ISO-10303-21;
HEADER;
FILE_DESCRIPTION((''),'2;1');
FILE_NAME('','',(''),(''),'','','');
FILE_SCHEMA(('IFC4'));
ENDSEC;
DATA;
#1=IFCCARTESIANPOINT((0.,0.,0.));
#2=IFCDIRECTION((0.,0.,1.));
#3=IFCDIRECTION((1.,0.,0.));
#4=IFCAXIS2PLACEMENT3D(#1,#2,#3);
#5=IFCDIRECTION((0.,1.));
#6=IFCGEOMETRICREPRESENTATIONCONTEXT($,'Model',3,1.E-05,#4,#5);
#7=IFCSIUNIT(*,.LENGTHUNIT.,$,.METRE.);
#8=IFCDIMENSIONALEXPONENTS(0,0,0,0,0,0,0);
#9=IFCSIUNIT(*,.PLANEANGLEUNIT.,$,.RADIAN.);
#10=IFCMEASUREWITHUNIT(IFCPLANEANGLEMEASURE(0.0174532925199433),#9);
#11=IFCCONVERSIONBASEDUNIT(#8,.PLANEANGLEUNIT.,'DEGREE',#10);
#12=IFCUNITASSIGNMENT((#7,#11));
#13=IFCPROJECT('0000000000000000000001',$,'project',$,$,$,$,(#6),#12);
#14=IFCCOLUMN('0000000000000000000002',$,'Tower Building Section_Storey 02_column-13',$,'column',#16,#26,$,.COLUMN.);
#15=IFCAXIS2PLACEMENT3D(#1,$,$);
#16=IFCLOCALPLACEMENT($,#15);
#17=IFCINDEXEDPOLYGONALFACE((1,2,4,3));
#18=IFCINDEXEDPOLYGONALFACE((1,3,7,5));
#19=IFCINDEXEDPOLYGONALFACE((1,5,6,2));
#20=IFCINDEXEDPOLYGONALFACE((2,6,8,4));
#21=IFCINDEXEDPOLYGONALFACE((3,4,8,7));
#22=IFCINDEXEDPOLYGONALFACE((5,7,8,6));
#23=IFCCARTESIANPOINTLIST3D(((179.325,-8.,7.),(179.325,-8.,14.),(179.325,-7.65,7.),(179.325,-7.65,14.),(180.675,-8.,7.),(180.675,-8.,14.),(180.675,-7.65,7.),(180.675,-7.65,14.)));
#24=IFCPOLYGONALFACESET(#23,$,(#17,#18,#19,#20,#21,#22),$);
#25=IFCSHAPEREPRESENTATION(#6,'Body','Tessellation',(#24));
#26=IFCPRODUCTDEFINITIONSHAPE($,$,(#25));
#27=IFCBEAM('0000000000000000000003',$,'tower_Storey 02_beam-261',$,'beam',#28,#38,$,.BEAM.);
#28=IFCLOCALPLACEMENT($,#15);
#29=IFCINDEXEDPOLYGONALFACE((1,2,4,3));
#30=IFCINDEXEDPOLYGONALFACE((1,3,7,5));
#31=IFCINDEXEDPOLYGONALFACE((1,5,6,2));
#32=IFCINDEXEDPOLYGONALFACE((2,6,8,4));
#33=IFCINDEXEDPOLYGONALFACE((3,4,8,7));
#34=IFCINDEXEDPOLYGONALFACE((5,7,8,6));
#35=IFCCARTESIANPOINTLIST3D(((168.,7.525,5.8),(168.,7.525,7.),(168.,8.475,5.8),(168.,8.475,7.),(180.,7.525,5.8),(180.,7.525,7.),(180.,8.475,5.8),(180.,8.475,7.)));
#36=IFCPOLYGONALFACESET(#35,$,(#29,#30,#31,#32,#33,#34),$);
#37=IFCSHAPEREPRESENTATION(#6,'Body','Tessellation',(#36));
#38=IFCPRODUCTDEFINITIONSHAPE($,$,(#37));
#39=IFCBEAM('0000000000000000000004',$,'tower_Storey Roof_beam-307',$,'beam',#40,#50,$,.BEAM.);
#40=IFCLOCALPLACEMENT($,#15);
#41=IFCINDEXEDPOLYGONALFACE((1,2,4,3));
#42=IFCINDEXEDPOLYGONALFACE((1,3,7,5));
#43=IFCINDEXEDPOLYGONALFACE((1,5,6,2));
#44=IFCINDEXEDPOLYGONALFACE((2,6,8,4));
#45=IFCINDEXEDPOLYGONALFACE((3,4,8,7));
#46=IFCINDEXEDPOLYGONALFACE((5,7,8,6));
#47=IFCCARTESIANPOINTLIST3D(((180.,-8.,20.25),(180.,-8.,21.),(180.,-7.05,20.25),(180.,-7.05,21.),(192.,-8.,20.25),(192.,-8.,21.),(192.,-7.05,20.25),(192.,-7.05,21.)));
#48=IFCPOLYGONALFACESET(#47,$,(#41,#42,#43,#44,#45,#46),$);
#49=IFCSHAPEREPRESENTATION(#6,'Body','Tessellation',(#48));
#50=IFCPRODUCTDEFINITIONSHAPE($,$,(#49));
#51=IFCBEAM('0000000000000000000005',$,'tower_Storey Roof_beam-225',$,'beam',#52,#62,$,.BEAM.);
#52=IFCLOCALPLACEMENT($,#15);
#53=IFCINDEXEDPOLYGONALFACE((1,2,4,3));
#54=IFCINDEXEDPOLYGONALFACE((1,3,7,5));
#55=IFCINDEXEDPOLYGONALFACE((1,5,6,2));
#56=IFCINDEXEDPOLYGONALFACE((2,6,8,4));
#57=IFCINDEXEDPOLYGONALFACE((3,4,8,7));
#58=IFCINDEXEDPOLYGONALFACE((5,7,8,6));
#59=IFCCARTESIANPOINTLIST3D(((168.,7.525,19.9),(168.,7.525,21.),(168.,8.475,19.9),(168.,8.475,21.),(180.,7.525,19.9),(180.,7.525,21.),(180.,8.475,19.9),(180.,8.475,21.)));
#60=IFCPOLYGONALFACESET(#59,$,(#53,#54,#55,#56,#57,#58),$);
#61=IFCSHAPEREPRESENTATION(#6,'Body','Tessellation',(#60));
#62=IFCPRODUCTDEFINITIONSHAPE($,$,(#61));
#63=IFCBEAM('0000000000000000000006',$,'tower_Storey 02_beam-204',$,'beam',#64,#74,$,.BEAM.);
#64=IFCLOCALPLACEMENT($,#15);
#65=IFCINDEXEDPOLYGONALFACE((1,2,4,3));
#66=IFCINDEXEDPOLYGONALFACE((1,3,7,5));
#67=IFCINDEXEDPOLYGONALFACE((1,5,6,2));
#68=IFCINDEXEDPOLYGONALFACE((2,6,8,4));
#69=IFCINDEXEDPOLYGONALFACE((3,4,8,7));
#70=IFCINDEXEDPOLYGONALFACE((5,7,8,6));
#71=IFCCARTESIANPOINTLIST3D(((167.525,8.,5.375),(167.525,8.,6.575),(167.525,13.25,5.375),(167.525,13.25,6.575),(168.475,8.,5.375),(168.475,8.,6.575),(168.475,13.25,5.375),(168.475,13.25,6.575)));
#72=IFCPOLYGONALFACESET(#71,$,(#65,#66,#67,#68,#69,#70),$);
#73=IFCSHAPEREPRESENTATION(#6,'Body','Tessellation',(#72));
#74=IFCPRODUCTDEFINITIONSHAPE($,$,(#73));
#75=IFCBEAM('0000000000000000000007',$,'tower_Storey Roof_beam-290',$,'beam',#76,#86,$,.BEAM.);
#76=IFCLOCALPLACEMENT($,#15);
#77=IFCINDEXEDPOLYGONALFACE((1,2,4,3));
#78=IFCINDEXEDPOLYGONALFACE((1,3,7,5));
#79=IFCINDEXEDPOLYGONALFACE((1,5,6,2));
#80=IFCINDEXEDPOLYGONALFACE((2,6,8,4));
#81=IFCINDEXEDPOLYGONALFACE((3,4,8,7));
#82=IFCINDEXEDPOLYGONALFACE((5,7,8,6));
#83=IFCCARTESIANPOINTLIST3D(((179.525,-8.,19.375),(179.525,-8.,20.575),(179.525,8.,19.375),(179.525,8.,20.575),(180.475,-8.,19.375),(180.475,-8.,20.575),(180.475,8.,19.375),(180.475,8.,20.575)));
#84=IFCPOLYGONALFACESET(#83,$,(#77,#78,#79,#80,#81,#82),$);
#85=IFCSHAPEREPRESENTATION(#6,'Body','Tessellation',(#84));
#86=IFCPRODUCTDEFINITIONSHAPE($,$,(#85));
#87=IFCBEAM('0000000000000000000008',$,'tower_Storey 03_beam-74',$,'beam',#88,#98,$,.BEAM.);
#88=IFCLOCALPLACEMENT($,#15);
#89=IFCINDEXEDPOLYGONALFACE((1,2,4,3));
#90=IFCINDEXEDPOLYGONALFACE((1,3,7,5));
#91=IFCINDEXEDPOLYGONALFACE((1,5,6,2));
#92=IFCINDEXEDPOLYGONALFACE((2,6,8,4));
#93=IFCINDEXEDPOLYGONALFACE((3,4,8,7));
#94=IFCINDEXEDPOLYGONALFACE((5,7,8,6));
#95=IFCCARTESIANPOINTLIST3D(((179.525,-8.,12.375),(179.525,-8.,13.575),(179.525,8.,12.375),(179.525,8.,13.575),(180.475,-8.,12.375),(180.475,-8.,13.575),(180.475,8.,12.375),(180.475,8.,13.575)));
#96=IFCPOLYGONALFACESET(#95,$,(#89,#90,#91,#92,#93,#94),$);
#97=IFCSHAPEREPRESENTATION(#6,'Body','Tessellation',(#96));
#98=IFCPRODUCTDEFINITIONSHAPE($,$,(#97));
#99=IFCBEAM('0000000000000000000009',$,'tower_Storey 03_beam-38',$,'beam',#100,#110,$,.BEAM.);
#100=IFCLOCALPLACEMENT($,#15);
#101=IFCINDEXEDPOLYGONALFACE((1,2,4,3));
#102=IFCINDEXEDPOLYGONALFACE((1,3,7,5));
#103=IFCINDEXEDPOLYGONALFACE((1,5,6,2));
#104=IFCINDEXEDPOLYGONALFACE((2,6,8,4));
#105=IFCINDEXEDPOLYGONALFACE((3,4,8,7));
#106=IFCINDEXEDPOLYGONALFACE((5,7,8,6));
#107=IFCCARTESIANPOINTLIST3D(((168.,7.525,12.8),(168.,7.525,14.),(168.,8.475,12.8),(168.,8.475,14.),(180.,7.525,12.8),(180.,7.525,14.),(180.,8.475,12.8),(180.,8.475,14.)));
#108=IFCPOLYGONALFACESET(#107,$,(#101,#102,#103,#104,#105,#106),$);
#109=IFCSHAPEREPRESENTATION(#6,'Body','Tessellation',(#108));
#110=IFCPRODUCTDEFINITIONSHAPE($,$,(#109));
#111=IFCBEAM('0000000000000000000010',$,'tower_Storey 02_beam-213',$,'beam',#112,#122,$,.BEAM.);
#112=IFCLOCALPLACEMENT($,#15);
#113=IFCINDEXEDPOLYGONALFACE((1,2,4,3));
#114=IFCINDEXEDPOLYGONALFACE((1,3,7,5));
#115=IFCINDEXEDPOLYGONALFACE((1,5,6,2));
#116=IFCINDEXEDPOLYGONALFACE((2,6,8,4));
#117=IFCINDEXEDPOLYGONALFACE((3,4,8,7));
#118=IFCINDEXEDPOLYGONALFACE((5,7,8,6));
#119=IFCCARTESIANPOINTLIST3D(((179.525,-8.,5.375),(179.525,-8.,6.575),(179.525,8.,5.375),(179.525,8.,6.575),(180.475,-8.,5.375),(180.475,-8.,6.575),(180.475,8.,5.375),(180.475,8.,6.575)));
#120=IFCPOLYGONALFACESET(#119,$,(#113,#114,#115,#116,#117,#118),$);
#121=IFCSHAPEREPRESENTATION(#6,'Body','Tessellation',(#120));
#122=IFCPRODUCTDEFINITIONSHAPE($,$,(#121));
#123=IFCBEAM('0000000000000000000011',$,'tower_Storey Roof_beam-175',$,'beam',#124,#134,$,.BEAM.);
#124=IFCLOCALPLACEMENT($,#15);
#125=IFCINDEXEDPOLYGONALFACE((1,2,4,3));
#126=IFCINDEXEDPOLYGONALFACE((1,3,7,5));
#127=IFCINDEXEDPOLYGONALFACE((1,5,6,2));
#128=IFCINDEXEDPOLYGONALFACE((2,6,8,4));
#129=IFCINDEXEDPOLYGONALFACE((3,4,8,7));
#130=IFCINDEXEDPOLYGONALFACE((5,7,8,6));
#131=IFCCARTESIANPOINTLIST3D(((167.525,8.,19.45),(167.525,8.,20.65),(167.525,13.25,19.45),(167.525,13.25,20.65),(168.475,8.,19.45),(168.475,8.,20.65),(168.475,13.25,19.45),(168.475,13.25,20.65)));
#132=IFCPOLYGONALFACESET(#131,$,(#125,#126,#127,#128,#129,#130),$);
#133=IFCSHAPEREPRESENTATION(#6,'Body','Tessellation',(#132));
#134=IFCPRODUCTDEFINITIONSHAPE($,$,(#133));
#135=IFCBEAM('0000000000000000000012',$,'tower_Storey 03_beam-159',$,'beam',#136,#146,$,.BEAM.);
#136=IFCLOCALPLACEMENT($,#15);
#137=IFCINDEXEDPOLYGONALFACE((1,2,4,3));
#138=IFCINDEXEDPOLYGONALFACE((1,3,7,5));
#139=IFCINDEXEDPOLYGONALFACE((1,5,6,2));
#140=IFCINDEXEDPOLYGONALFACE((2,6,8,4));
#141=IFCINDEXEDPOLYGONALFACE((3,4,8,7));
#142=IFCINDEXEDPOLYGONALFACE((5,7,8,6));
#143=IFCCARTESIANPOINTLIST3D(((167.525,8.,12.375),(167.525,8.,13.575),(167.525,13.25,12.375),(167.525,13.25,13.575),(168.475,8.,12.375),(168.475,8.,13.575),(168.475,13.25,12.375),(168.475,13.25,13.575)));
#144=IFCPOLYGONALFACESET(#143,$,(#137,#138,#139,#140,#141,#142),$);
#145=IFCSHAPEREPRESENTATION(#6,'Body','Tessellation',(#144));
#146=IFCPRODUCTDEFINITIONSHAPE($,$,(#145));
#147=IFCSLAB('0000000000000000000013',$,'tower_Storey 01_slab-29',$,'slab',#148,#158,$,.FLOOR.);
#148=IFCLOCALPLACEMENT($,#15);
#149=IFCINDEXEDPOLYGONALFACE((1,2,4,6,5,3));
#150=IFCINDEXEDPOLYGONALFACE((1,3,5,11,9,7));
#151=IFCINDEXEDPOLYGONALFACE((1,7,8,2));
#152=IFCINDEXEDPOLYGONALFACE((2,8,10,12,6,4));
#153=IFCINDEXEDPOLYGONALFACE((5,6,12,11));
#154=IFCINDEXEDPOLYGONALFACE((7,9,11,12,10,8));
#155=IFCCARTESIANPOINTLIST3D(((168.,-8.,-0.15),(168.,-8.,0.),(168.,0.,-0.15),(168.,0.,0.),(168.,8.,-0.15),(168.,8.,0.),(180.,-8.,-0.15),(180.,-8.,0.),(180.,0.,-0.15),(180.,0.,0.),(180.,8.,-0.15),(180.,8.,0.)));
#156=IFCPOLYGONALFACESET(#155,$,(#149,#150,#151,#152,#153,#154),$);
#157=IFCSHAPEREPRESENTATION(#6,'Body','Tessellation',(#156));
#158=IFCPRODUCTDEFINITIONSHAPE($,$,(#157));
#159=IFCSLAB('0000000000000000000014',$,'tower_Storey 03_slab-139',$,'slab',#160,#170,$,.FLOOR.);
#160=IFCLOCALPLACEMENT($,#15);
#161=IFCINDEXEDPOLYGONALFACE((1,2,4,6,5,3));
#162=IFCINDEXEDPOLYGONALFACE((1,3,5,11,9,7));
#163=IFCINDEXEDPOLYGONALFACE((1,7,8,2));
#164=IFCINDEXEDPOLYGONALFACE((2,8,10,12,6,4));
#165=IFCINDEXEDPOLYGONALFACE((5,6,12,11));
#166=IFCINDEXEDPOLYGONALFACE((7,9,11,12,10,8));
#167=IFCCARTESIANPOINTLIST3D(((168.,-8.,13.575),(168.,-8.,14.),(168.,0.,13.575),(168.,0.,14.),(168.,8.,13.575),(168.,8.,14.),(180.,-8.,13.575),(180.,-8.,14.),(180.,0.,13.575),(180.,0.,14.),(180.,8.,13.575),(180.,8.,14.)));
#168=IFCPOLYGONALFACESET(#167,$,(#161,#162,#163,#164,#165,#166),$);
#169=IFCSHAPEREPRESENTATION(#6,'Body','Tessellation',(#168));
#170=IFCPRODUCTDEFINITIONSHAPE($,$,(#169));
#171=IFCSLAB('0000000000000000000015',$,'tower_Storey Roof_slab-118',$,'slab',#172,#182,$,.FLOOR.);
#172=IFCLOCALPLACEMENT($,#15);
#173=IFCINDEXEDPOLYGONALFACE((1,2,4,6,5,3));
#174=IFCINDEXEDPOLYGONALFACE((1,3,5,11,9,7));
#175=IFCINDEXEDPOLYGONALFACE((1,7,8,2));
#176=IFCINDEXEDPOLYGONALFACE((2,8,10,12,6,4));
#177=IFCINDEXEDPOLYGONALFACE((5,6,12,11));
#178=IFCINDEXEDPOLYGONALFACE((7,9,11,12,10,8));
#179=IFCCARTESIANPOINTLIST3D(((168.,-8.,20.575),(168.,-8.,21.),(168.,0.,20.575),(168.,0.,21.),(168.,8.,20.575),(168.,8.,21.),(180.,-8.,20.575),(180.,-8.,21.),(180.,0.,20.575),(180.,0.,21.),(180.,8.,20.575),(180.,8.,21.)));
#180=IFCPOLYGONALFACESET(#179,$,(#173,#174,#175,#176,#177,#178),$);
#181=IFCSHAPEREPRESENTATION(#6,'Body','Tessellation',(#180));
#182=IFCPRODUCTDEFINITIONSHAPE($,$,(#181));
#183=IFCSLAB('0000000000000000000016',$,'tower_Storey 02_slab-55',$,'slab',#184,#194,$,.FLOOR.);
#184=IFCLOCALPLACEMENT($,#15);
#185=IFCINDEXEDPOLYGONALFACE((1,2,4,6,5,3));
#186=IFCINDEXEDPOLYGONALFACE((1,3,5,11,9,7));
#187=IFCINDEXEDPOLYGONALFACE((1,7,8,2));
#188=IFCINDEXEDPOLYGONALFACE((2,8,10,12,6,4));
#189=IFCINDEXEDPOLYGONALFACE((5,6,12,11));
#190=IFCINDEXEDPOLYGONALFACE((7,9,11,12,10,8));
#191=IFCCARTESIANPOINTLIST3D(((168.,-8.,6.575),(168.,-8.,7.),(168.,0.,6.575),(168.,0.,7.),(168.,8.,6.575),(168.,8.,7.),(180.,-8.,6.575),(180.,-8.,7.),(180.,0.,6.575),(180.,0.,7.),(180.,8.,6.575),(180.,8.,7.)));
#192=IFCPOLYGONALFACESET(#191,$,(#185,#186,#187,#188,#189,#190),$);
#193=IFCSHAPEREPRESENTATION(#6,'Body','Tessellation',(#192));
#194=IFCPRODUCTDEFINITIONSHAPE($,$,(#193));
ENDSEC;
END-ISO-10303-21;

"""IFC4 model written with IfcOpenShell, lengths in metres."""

from ifc_helpers import new_model, entity, si_unit, converted_unit, direction, frame, origin_with_axes, place, context, project, polyline, outline, extrude, element, save


model = new_model("IFC4")

# Units and contexts
model_context = context("Model", 3, precision=1e-05, world=origin_with_axes(), true_north=direction((0.0, 1.0)))
ifc_project = project(units=[si_unit("LENGTHUNIT", "METRE"), converted_unit("PLANEANGLEUNIT", "DEGREE", entity("IfcPlaneAngleMeasure", 0.0174532925199433), si_unit("PLANEANGLEUNIT", "RADIAN"), dimensions=[0, 0, 0, 0, 0, 0, 0])], contexts=[model_context])

# Shared definitions
placement_1 = place(None, origin_with_axes())
placement_2 = place(placement_1, origin_with_axes())

# Column
placement_3 = place(placement_1, frame((0.0, 0.0, 14.0), z_axis=(0.0, 0.0, 1.0), x_axis=(1.0, 0.0, 0.0)))
placement_4 = place(placement_1, frame((0.0, 0.0, 7.0), z_axis=(0.0, 0.0, 1.0), x_axis=(1.0, 0.0, 0.0)))
column_1_placement = place(placement_4, frame((180.0, -7.825, 0.0), z_axis=(0.0, 0.0, 1.0), x_axis=(1.0, 0.0, 0.0)))
element("IfcColumn", 1, at=column_1_placement, Name="Tower Building Section_Storey 02_column-13", ObjectType="column", PredefinedType="COLUMN", context=model_context, body=[
    extrude(outline(polyline([(-0.675, -0.175, 0.0), (0.675, -0.175, 0.0), (0.675, 0.175, 0.0), (-0.675, 0.175, 0.0), (-0.675, -0.175, 0.0)])), origin_with_axes(), (0.0, 0.0, 1.0), 7.0),
])

# Beams
beam_1_placement = place(placement_4, frame((168.0, 8.0, -0.6), z_axis=(1.0, 0.0, 0.0), x_axis=(0.0, 1.0, 0.0)))
element("IfcBeam", 2, at=beam_1_placement, Name="tower_Storey 02_beam-261", ObjectType="beam", PredefinedType="BEAM", context=model_context, body=[
    extrude(outline(polyline([(0.475, 0.6, 0.0), (-0.475, 0.6, 0.0), (-0.475, -0.6, 0.0), (0.475, -0.6, 0.0), (0.475, 0.6, 0.0)])), origin_with_axes(), (0.0, 0.0, 1.0), 12.0),
])
placement_5 = place(placement_1, frame((0.0, 0.0, 21.0), z_axis=(0.0, 0.0, 1.0), x_axis=(1.0, 0.0, 0.0)))
beam_2_placement = place(placement_5, frame((180.0, -7.525, -0.375), z_axis=(1.0, 0.0, 0.0), x_axis=(0.0, 1.0, 0.0)))
element("IfcBeam", 3, at=beam_2_placement, Name="tower_Storey Roof_beam-307", ObjectType="beam", PredefinedType="BEAM", context=model_context, body=[
    extrude(outline(polyline([(0.475, 0.375, 0.0), (-0.475, 0.375, 0.0), (-0.475, -0.375, 0.0), (0.475, -0.375, 0.0), (0.475, 0.375, 0.0)])), origin_with_axes(), (0.0, 0.0, 1.0), 12.0),
])
beam_3_placement = place(placement_5, frame((168.0, 8.0, -0.55), z_axis=(1.0, 0.0, 0.0), x_axis=(0.0, 1.0, 0.0)))
element("IfcBeam", 4, at=beam_3_placement, Name="tower_Storey Roof_beam-225", ObjectType="beam", PredefinedType="BEAM", context=model_context, body=[
    extrude(outline(polyline([(0.475, 0.55, 0.0), (-0.475, 0.55, 0.0), (-0.475, -0.55, 0.0), (0.475, -0.55, 0.0), (0.475, 0.55, 0.0)])), origin_with_axes(), (0.0, 0.0, 1.0), 12.0),
])
beam_4_placement = place(placement_4, frame((168.0, 8.0, -1.025), z_axis=(0.0, 1.0, 0.0), x_axis=(-1.0, 0.0, 0.0)))
element("IfcBeam", 5, at=beam_4_placement, Name="tower_Storey 02_beam-204", ObjectType="beam", PredefinedType="BEAM", context=model_context, body=[
    extrude(outline(polyline([(0.475, 0.6, 0.0), (-0.475, 0.6, 0.0), (-0.475, -0.6, 0.0), (0.475, -0.6, 0.0), (0.475, 0.6, 0.0)])), origin_with_axes(), (0.0, 0.0, 1.0), 5.25),
])
beam_5_placement = place(placement_5, frame((180.0, -8.0, -1.025), z_axis=(0.0, 1.0, 0.0), x_axis=(-1.0, 0.0, 0.0)))
element("IfcBeam", 6, at=beam_5_placement, Name="tower_Storey Roof_beam-290", ObjectType="beam", PredefinedType="BEAM", context=model_context, body=[
    extrude(outline(polyline([(0.475, 0.6, 0.0), (-0.475, 0.6, 0.0), (-0.475, -0.6, 0.0), (0.475, -0.6, 0.0), (0.475, 0.6, 0.0)])), origin_with_axes(), (0.0, 0.0, 1.0), 16.0),
])
beam_6_placement = place(placement_3, frame((180.0, -8.0, -1.025), z_axis=(0.0, 1.0, 0.0), x_axis=(-1.0, 0.0, 0.0)))
element("IfcBeam", 7, at=beam_6_placement, Name="tower_Storey 03_beam-74", ObjectType="beam", PredefinedType="BEAM", context=model_context, body=[
    extrude(outline(polyline([(0.475, 0.6, 0.0), (-0.475, 0.6, 0.0), (-0.475, -0.6, 0.0), (0.475, -0.6, 0.0), (0.475, 0.6, 0.0)])), origin_with_axes(), (0.0, 0.0, 1.0), 16.0),
])
beam_7_placement = place(placement_3, frame((168.0, 8.0, -0.6), z_axis=(1.0, 0.0, 0.0), x_axis=(0.0, 1.0, 0.0)))
element("IfcBeam", 8, at=beam_7_placement, Name="tower_Storey 03_beam-38", ObjectType="beam", PredefinedType="BEAM", context=model_context, body=[
    extrude(outline(polyline([(0.475, 0.6, 0.0), (-0.475, 0.6, 0.0), (-0.475, -0.6, 0.0), (0.475, -0.6, 0.0), (0.475, 0.6, 0.0)])), origin_with_axes(), (0.0, 0.0, 1.0), 12.0),
])
beam_8_placement = place(placement_4, frame((180.0, -8.0, -1.025), z_axis=(0.0, 1.0, 0.0), x_axis=(-1.0, 0.0, 0.0)))
element("IfcBeam", 9, at=beam_8_placement, Name="tower_Storey 02_beam-213", ObjectType="beam", PredefinedType="BEAM", context=model_context, body=[
    extrude(outline(polyline([(0.475, 0.6, 0.0), (-0.475, 0.6, 0.0), (-0.475, -0.6, 0.0), (0.475, -0.6, 0.0), (0.475, 0.6, 0.0)])), origin_with_axes(), (0.0, 0.0, 1.0), 16.0),
])
beam_9_placement = place(placement_5, frame((168.0, 8.0, -0.95), z_axis=(0.0, 1.0, 0.0), x_axis=(-1.0, 0.0, 0.0)))
element("IfcBeam", 10, at=beam_9_placement, Name="tower_Storey Roof_beam-175", ObjectType="beam", PredefinedType="BEAM", context=model_context, body=[
    extrude(outline(polyline([(0.475, 0.6, 0.0), (-0.475, 0.6, 0.0), (-0.475, -0.6, 0.0), (0.475, -0.6, 0.0), (0.475, 0.6, 0.0)])), origin_with_axes(), (0.0, 0.0, 1.0), 5.25),
])
beam_10_placement = place(placement_3, frame((168.0, 8.0, -1.025), z_axis=(0.0, 1.0, 0.0), x_axis=(-1.0, 0.0, 0.0)))
element("IfcBeam", 11, at=beam_10_placement, Name="tower_Storey 03_beam-159", ObjectType="beam", PredefinedType="BEAM", context=model_context, body=[
    extrude(outline(polyline([(0.475, 0.6, 0.0), (-0.475, 0.6, 0.0), (-0.475, -0.6, 0.0), (0.475, -0.6, 0.0), (0.475, 0.6, 0.0)])), origin_with_axes(), (0.0, 0.0, 1.0), 5.25),
])

# Slabs
slab_1_placement = place(placement_2, frame((174.0, 0.0, -0.15), z_axis=(0.0, 0.0, 1.0), x_axis=(1.0, 0.0, 0.0)))
element("IfcSlab", 12, at=slab_1_placement, Name="tower_Storey 01_slab-29", ObjectType="slab", PredefinedType="FLOOR", context=model_context, body=[
    extrude(outline(polyline([(-6.0, -8.0, 0.0), (6.0, -8.0, 0.0), (6.0, 0.0, 0.0), (6.0, 8.0, 0.0), (-6.0, 8.0, 0.0), (-6.0, 0.0, 0.0), (-6.0, -8.0, 0.0)])), origin_with_axes(), (0.0, 0.0, 1.0), 0.15),
])
slab_2_placement = place(placement_3, frame((174.0, 0.0, -0.425), z_axis=(0.0, 0.0, 1.0), x_axis=(1.0, 0.0, 0.0)))
element("IfcSlab", 13, at=slab_2_placement, Name="tower_Storey 03_slab-139", ObjectType="slab", PredefinedType="FLOOR", context=model_context, body=[
    extrude(outline(polyline([(-6.0, -8.0, 0.0), (6.0, -8.0, 0.0), (6.0, 0.0, 0.0), (6.0, 8.0, 0.0), (-6.0, 8.0, 0.0), (-6.0, 0.0, 0.0), (-6.0, -8.0, 0.0)])), origin_with_axes(), (0.0, 0.0, 1.0), 0.425),
])
slab_3_placement = place(placement_5, frame((174.0, 0.0, -0.425), z_axis=(0.0, 0.0, 1.0), x_axis=(1.0, 0.0, 0.0)))
element("IfcSlab", 14, at=slab_3_placement, Name="tower_Storey Roof_slab-118", ObjectType="slab", PredefinedType="FLOOR", context=model_context, body=[
    extrude(outline(polyline([(-6.0, -8.0, 0.0), (6.0, -8.0, 0.0), (6.0, 0.0, 0.0), (6.0, 8.0, 0.0), (-6.0, 8.0, 0.0), (-6.0, 0.0, 0.0), (-6.0, -8.0, 0.0)])), origin_with_axes(), (0.0, 0.0, 1.0), 0.425),
])
slab_4_placement = place(placement_4, frame((174.0, 0.0, -0.425), z_axis=(0.0, 0.0, 1.0), x_axis=(1.0, 0.0, 0.0)))
element("IfcSlab", 15, at=slab_4_placement, Name="tower_Storey 02_slab-55", ObjectType="slab", PredefinedType="FLOOR", context=model_context, body=[
    extrude(outline(polyline([(-6.0, -8.0, 0.0), (6.0, -8.0, 0.0), (6.0, 0.0, 0.0), (6.0, 8.0, 0.0), (-6.0, 8.0, 0.0), (-6.0, 0.0, 0.0), (-6.0, -8.0, 0.0)])), origin_with_axes(), (0.0, 0.0, 1.0), 0.425),
])

save(model, "model.ifc")
